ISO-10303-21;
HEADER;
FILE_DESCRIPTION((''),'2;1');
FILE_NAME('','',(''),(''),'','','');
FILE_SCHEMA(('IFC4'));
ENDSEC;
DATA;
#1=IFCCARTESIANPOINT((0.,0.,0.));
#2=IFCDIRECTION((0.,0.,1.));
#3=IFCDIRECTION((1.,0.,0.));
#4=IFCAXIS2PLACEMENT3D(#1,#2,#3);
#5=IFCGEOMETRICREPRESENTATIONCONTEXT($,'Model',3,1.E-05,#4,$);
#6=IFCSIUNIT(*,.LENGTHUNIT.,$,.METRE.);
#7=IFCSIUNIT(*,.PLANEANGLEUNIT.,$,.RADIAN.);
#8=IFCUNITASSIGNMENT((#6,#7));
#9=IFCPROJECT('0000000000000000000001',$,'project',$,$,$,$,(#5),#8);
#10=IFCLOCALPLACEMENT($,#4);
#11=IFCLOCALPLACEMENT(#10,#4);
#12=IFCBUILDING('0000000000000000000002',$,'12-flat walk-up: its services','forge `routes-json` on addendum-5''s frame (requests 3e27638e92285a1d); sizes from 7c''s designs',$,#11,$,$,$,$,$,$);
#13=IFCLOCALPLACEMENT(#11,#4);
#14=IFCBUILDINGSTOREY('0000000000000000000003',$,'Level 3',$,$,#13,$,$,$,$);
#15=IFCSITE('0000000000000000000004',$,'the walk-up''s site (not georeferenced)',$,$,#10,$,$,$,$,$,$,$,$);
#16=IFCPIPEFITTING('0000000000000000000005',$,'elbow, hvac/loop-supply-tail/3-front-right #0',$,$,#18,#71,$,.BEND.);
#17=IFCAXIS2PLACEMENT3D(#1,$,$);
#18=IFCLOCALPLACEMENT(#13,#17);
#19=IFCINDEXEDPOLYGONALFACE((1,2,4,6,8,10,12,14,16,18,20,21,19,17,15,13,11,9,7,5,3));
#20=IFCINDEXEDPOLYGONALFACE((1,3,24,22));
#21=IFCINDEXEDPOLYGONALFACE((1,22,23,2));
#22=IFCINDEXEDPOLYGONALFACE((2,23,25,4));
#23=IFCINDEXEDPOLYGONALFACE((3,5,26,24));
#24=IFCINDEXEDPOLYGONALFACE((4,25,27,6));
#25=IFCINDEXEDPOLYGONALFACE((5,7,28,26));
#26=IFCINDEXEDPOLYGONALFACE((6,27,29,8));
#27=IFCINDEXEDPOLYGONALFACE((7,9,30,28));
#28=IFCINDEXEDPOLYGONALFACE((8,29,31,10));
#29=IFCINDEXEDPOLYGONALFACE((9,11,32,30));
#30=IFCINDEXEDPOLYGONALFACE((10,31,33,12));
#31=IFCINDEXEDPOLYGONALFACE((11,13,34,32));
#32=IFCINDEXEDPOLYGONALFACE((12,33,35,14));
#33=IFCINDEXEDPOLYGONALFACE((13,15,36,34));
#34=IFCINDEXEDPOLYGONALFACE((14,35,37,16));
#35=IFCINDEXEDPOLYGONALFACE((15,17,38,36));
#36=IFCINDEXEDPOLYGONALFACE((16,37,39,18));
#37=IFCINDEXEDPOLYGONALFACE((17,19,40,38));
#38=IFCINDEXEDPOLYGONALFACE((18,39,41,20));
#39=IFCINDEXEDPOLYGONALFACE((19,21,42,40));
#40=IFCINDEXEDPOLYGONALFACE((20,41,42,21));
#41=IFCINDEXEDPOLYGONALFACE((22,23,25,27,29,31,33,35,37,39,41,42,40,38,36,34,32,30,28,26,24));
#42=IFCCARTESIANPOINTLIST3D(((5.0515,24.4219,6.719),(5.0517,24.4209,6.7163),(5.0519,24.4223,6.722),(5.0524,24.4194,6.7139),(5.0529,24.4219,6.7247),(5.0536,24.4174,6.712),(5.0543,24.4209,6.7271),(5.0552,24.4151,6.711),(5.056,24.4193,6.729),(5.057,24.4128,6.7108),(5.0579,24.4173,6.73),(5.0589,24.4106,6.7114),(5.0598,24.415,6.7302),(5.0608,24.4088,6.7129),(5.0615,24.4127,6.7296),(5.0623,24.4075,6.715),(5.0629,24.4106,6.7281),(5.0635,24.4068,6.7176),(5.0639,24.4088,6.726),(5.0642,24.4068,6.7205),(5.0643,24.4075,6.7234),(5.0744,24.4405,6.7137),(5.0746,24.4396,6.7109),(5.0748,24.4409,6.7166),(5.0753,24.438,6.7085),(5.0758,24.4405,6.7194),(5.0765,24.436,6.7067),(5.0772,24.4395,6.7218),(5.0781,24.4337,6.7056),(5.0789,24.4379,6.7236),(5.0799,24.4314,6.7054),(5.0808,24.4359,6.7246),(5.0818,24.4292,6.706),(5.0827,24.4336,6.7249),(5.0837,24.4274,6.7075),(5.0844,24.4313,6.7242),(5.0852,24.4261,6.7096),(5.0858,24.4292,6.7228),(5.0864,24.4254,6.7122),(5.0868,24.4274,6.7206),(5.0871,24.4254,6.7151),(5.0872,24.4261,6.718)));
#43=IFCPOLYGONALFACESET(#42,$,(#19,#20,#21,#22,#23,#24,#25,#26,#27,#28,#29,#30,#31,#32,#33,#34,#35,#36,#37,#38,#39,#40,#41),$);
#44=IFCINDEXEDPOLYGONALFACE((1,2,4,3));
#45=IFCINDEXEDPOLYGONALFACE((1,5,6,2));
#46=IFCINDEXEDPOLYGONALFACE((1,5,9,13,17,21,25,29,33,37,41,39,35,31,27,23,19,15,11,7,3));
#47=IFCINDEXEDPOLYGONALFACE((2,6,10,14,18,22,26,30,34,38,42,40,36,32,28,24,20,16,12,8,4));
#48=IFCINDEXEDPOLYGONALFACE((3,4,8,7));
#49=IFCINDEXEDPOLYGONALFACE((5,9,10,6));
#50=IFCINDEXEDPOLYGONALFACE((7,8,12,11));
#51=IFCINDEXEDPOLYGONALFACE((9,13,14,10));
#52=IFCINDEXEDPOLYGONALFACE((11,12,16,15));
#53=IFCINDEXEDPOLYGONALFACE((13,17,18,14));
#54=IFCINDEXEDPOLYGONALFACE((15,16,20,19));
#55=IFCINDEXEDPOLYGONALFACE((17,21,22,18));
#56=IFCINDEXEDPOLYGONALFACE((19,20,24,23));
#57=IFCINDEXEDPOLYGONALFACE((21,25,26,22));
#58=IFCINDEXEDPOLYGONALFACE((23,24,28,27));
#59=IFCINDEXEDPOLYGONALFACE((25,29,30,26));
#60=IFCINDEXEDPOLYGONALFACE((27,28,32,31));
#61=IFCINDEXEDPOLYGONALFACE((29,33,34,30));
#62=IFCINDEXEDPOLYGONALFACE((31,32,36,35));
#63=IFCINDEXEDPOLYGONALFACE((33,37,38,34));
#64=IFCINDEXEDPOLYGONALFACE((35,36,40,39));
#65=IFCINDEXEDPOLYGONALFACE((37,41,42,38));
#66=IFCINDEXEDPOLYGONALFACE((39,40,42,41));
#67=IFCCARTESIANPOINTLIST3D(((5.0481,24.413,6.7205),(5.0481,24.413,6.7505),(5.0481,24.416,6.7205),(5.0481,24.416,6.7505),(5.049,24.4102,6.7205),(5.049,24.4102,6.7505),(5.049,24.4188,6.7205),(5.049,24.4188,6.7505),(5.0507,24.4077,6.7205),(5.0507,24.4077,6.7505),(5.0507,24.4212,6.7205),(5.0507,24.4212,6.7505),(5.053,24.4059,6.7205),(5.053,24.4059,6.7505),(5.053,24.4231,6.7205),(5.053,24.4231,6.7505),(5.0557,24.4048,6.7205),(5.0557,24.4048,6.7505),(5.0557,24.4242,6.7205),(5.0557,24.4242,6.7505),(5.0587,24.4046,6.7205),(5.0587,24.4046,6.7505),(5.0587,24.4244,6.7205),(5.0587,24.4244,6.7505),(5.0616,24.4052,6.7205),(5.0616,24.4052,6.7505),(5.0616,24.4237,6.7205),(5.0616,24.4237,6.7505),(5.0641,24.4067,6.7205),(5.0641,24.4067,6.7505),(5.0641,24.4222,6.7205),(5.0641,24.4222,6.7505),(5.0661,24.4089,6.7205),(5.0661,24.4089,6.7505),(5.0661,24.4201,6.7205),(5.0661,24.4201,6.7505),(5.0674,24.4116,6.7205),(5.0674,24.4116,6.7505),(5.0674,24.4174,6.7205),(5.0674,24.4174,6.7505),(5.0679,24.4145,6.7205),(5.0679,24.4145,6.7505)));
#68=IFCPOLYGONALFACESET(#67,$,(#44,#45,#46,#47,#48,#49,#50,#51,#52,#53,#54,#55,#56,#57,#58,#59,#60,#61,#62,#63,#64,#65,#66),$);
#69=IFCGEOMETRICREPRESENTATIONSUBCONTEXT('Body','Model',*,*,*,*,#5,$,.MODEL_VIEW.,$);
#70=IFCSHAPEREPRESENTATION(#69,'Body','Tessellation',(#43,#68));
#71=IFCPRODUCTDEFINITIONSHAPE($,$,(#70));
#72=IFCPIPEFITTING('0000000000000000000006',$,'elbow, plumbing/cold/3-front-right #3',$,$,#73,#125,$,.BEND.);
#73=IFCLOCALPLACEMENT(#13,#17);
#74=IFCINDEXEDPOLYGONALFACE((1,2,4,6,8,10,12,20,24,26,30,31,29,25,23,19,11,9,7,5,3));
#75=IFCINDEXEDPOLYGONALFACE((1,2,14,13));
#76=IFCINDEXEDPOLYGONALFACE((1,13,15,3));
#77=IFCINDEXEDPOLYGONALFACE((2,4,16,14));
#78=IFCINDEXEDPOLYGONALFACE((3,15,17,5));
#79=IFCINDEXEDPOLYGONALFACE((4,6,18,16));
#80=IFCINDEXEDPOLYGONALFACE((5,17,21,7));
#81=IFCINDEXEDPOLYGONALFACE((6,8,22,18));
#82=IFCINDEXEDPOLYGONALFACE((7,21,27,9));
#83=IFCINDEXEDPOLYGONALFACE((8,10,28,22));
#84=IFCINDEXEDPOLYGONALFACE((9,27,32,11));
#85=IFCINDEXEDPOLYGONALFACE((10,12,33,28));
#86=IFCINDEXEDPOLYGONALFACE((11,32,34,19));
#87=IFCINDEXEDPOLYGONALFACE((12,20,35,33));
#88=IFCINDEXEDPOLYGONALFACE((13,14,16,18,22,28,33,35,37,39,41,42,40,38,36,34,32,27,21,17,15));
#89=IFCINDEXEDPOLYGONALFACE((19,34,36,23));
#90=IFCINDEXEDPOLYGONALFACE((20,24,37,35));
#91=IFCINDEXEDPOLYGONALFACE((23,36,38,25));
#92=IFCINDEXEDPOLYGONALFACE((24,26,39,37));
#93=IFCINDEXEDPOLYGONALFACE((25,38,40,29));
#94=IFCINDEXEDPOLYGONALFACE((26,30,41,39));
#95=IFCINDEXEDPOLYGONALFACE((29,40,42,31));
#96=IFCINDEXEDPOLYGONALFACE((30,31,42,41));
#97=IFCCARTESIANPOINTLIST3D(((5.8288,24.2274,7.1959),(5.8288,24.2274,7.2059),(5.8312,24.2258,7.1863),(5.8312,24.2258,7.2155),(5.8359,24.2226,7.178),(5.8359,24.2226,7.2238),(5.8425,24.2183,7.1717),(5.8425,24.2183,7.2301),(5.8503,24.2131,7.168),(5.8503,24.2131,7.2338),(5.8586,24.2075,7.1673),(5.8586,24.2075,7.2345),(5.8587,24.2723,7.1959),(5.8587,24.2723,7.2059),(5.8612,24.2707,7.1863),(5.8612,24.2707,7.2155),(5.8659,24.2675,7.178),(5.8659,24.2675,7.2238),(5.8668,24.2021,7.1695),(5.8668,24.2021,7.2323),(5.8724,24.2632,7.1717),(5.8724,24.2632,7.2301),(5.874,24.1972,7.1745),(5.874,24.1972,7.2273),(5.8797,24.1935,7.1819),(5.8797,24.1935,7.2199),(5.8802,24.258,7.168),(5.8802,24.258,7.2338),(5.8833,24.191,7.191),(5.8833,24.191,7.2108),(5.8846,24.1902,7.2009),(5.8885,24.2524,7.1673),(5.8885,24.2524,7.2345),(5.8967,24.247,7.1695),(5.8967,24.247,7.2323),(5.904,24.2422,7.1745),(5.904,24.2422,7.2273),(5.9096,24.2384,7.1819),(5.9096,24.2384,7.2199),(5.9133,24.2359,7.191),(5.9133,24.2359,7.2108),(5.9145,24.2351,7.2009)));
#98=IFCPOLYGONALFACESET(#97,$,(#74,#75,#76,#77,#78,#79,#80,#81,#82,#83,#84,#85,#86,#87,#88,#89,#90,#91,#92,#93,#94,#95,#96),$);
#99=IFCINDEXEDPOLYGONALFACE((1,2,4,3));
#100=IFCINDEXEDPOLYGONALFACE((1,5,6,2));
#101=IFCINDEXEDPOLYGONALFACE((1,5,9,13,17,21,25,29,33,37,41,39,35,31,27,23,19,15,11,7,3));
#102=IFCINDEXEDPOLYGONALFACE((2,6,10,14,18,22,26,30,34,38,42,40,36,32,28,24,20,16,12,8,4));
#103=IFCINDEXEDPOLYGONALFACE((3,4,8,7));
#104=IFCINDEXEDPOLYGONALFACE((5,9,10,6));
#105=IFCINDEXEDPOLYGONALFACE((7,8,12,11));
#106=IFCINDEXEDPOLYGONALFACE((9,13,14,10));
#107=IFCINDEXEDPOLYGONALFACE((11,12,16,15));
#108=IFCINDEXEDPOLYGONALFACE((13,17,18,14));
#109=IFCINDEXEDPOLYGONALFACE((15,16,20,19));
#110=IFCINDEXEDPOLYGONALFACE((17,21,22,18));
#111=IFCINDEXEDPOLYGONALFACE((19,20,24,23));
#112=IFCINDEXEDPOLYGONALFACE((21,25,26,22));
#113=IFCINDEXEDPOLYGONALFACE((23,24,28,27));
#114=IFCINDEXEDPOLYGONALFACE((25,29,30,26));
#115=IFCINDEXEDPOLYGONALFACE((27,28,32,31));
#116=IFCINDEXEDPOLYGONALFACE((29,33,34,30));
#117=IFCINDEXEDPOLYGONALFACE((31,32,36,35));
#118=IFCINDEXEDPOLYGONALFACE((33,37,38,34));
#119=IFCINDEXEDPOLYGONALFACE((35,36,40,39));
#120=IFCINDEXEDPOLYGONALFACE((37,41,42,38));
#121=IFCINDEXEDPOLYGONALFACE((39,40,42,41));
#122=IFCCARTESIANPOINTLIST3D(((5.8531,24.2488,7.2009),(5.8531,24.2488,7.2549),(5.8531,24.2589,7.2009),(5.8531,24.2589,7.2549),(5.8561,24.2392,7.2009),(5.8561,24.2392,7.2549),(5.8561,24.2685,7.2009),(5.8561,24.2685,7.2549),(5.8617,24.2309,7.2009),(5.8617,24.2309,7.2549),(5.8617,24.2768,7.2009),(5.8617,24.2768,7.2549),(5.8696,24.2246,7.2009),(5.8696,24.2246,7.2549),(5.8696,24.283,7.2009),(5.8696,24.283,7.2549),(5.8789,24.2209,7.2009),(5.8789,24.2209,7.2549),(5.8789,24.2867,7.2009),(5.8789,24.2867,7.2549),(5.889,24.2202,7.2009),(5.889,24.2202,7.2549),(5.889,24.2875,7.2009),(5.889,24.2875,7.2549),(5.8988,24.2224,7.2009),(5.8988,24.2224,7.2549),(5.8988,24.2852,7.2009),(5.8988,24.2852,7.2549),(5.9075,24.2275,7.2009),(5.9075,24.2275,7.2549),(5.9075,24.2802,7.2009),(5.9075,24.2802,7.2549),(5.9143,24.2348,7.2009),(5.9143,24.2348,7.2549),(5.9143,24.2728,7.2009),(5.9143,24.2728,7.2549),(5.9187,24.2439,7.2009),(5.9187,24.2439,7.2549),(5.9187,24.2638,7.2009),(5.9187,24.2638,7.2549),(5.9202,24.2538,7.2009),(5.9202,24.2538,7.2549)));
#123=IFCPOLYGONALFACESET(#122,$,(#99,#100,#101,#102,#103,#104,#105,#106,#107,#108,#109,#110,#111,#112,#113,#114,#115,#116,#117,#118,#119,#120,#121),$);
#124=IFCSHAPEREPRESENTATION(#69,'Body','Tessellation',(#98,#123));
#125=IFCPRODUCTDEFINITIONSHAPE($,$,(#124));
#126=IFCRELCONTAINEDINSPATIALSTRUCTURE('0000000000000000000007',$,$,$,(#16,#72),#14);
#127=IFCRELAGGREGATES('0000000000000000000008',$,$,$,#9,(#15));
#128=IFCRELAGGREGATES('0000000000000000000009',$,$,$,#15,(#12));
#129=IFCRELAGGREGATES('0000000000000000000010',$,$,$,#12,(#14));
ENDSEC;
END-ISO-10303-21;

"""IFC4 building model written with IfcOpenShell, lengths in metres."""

from ifc_helpers import new_model, entity, si_unit, frame, origin_with_axes, place, context, subcontext, project, spatial, element, save


model = new_model("IFC4")

# Units and contexts
model_context = context("Model", 3, precision=1e-05, world=origin_with_axes())
body_context = subcontext(model_context, "Body", "Model", "MODEL_VIEW")
ifc_project = project(units=[si_unit("LENGTHUNIT", "METRE"), si_unit("PLANEANGLEUNIT", "RADIAN")], contexts=[model_context])

# Site, building, storey
site_placement = place(None, origin_with_axes())
site = spatial("IfcSite", under=ifc_project, at=site_placement, Name="the walk-up's site (not georeferenced)")
building_placement = place(site_placement, origin_with_axes())
building = spatial("IfcBuilding", under=site, at=building_placement, Name="12-flat walk-up: its services", Description="forge `routes-json` on addendum-5's frame (requests 3e27638e92285a1d); sizes from 7c's designs")
storey_placement = place(building_placement, origin_with_axes())
storey = spatial("IfcBuildingStorey", under=building, at=storey_placement, Name="Level 3")

# Pipe fittings
pipe_fitting_1_placement = place(storey_placement, frame((5.0808, 24.4331, 6.7151), z_axis=(0.0, 0.0, 1.0), x_axis=(1.0, 0.0, 0.0)))
element("IfcPipeFitting", 1, at=pipe_fitting_1_placement, inside=storey, Name="elbow, hvac/loop-supply-tail/3-front-right #0", PredefinedType="BEND", context=body_context, shape_type="AdvancedSweptSolid", body=[
    entity("IfcSweptDiskSolid", entity("IfcPolyline", [entity("IfcCartesianPoint", [0.0, 0.0, 0.0]), entity("IfcCartesianPoint", [-0.0229, -0.0186, 0.0054])]), 0.0099),
    entity("IfcSweptDiskSolid", entity("IfcPolyline", [entity("IfcCartesianPoint", [-0.0229, -0.0186, 0.0054]), entity("IfcCartesianPoint", [-0.0229, -0.0186, 0.0354])]), 0.0099),
])
pipe_fitting_2_placement = place(storey_placement, frame((5.8565, 24.2089, 7.2009), z_axis=(0.0, 0.0, 1.0), x_axis=(1.0, 0.0, 0.0)))
element("IfcPipeFitting", 2, at=pipe_fitting_2_placement, inside=storey, Name="elbow, plumbing/cold/3-front-right #3", PredefinedType="BEND", context=body_context, shape_type="AdvancedSweptSolid", body=[
    entity("IfcSweptDiskSolid", entity("IfcPolyline", [entity("IfcCartesianPoint", [0.0, 0.0, 0.0]), entity("IfcCartesianPoint", [0.0299, 0.0449, 0.0])]), 0.0337),
    entity("IfcSweptDiskSolid", entity("IfcPolyline", [entity("IfcCartesianPoint", [0.0299, 0.0449, 0.0]), entity("IfcCartesianPoint", [0.0299, 0.0449, 0.054])]), 0.0337),
])

save(model, "model.ifc")
